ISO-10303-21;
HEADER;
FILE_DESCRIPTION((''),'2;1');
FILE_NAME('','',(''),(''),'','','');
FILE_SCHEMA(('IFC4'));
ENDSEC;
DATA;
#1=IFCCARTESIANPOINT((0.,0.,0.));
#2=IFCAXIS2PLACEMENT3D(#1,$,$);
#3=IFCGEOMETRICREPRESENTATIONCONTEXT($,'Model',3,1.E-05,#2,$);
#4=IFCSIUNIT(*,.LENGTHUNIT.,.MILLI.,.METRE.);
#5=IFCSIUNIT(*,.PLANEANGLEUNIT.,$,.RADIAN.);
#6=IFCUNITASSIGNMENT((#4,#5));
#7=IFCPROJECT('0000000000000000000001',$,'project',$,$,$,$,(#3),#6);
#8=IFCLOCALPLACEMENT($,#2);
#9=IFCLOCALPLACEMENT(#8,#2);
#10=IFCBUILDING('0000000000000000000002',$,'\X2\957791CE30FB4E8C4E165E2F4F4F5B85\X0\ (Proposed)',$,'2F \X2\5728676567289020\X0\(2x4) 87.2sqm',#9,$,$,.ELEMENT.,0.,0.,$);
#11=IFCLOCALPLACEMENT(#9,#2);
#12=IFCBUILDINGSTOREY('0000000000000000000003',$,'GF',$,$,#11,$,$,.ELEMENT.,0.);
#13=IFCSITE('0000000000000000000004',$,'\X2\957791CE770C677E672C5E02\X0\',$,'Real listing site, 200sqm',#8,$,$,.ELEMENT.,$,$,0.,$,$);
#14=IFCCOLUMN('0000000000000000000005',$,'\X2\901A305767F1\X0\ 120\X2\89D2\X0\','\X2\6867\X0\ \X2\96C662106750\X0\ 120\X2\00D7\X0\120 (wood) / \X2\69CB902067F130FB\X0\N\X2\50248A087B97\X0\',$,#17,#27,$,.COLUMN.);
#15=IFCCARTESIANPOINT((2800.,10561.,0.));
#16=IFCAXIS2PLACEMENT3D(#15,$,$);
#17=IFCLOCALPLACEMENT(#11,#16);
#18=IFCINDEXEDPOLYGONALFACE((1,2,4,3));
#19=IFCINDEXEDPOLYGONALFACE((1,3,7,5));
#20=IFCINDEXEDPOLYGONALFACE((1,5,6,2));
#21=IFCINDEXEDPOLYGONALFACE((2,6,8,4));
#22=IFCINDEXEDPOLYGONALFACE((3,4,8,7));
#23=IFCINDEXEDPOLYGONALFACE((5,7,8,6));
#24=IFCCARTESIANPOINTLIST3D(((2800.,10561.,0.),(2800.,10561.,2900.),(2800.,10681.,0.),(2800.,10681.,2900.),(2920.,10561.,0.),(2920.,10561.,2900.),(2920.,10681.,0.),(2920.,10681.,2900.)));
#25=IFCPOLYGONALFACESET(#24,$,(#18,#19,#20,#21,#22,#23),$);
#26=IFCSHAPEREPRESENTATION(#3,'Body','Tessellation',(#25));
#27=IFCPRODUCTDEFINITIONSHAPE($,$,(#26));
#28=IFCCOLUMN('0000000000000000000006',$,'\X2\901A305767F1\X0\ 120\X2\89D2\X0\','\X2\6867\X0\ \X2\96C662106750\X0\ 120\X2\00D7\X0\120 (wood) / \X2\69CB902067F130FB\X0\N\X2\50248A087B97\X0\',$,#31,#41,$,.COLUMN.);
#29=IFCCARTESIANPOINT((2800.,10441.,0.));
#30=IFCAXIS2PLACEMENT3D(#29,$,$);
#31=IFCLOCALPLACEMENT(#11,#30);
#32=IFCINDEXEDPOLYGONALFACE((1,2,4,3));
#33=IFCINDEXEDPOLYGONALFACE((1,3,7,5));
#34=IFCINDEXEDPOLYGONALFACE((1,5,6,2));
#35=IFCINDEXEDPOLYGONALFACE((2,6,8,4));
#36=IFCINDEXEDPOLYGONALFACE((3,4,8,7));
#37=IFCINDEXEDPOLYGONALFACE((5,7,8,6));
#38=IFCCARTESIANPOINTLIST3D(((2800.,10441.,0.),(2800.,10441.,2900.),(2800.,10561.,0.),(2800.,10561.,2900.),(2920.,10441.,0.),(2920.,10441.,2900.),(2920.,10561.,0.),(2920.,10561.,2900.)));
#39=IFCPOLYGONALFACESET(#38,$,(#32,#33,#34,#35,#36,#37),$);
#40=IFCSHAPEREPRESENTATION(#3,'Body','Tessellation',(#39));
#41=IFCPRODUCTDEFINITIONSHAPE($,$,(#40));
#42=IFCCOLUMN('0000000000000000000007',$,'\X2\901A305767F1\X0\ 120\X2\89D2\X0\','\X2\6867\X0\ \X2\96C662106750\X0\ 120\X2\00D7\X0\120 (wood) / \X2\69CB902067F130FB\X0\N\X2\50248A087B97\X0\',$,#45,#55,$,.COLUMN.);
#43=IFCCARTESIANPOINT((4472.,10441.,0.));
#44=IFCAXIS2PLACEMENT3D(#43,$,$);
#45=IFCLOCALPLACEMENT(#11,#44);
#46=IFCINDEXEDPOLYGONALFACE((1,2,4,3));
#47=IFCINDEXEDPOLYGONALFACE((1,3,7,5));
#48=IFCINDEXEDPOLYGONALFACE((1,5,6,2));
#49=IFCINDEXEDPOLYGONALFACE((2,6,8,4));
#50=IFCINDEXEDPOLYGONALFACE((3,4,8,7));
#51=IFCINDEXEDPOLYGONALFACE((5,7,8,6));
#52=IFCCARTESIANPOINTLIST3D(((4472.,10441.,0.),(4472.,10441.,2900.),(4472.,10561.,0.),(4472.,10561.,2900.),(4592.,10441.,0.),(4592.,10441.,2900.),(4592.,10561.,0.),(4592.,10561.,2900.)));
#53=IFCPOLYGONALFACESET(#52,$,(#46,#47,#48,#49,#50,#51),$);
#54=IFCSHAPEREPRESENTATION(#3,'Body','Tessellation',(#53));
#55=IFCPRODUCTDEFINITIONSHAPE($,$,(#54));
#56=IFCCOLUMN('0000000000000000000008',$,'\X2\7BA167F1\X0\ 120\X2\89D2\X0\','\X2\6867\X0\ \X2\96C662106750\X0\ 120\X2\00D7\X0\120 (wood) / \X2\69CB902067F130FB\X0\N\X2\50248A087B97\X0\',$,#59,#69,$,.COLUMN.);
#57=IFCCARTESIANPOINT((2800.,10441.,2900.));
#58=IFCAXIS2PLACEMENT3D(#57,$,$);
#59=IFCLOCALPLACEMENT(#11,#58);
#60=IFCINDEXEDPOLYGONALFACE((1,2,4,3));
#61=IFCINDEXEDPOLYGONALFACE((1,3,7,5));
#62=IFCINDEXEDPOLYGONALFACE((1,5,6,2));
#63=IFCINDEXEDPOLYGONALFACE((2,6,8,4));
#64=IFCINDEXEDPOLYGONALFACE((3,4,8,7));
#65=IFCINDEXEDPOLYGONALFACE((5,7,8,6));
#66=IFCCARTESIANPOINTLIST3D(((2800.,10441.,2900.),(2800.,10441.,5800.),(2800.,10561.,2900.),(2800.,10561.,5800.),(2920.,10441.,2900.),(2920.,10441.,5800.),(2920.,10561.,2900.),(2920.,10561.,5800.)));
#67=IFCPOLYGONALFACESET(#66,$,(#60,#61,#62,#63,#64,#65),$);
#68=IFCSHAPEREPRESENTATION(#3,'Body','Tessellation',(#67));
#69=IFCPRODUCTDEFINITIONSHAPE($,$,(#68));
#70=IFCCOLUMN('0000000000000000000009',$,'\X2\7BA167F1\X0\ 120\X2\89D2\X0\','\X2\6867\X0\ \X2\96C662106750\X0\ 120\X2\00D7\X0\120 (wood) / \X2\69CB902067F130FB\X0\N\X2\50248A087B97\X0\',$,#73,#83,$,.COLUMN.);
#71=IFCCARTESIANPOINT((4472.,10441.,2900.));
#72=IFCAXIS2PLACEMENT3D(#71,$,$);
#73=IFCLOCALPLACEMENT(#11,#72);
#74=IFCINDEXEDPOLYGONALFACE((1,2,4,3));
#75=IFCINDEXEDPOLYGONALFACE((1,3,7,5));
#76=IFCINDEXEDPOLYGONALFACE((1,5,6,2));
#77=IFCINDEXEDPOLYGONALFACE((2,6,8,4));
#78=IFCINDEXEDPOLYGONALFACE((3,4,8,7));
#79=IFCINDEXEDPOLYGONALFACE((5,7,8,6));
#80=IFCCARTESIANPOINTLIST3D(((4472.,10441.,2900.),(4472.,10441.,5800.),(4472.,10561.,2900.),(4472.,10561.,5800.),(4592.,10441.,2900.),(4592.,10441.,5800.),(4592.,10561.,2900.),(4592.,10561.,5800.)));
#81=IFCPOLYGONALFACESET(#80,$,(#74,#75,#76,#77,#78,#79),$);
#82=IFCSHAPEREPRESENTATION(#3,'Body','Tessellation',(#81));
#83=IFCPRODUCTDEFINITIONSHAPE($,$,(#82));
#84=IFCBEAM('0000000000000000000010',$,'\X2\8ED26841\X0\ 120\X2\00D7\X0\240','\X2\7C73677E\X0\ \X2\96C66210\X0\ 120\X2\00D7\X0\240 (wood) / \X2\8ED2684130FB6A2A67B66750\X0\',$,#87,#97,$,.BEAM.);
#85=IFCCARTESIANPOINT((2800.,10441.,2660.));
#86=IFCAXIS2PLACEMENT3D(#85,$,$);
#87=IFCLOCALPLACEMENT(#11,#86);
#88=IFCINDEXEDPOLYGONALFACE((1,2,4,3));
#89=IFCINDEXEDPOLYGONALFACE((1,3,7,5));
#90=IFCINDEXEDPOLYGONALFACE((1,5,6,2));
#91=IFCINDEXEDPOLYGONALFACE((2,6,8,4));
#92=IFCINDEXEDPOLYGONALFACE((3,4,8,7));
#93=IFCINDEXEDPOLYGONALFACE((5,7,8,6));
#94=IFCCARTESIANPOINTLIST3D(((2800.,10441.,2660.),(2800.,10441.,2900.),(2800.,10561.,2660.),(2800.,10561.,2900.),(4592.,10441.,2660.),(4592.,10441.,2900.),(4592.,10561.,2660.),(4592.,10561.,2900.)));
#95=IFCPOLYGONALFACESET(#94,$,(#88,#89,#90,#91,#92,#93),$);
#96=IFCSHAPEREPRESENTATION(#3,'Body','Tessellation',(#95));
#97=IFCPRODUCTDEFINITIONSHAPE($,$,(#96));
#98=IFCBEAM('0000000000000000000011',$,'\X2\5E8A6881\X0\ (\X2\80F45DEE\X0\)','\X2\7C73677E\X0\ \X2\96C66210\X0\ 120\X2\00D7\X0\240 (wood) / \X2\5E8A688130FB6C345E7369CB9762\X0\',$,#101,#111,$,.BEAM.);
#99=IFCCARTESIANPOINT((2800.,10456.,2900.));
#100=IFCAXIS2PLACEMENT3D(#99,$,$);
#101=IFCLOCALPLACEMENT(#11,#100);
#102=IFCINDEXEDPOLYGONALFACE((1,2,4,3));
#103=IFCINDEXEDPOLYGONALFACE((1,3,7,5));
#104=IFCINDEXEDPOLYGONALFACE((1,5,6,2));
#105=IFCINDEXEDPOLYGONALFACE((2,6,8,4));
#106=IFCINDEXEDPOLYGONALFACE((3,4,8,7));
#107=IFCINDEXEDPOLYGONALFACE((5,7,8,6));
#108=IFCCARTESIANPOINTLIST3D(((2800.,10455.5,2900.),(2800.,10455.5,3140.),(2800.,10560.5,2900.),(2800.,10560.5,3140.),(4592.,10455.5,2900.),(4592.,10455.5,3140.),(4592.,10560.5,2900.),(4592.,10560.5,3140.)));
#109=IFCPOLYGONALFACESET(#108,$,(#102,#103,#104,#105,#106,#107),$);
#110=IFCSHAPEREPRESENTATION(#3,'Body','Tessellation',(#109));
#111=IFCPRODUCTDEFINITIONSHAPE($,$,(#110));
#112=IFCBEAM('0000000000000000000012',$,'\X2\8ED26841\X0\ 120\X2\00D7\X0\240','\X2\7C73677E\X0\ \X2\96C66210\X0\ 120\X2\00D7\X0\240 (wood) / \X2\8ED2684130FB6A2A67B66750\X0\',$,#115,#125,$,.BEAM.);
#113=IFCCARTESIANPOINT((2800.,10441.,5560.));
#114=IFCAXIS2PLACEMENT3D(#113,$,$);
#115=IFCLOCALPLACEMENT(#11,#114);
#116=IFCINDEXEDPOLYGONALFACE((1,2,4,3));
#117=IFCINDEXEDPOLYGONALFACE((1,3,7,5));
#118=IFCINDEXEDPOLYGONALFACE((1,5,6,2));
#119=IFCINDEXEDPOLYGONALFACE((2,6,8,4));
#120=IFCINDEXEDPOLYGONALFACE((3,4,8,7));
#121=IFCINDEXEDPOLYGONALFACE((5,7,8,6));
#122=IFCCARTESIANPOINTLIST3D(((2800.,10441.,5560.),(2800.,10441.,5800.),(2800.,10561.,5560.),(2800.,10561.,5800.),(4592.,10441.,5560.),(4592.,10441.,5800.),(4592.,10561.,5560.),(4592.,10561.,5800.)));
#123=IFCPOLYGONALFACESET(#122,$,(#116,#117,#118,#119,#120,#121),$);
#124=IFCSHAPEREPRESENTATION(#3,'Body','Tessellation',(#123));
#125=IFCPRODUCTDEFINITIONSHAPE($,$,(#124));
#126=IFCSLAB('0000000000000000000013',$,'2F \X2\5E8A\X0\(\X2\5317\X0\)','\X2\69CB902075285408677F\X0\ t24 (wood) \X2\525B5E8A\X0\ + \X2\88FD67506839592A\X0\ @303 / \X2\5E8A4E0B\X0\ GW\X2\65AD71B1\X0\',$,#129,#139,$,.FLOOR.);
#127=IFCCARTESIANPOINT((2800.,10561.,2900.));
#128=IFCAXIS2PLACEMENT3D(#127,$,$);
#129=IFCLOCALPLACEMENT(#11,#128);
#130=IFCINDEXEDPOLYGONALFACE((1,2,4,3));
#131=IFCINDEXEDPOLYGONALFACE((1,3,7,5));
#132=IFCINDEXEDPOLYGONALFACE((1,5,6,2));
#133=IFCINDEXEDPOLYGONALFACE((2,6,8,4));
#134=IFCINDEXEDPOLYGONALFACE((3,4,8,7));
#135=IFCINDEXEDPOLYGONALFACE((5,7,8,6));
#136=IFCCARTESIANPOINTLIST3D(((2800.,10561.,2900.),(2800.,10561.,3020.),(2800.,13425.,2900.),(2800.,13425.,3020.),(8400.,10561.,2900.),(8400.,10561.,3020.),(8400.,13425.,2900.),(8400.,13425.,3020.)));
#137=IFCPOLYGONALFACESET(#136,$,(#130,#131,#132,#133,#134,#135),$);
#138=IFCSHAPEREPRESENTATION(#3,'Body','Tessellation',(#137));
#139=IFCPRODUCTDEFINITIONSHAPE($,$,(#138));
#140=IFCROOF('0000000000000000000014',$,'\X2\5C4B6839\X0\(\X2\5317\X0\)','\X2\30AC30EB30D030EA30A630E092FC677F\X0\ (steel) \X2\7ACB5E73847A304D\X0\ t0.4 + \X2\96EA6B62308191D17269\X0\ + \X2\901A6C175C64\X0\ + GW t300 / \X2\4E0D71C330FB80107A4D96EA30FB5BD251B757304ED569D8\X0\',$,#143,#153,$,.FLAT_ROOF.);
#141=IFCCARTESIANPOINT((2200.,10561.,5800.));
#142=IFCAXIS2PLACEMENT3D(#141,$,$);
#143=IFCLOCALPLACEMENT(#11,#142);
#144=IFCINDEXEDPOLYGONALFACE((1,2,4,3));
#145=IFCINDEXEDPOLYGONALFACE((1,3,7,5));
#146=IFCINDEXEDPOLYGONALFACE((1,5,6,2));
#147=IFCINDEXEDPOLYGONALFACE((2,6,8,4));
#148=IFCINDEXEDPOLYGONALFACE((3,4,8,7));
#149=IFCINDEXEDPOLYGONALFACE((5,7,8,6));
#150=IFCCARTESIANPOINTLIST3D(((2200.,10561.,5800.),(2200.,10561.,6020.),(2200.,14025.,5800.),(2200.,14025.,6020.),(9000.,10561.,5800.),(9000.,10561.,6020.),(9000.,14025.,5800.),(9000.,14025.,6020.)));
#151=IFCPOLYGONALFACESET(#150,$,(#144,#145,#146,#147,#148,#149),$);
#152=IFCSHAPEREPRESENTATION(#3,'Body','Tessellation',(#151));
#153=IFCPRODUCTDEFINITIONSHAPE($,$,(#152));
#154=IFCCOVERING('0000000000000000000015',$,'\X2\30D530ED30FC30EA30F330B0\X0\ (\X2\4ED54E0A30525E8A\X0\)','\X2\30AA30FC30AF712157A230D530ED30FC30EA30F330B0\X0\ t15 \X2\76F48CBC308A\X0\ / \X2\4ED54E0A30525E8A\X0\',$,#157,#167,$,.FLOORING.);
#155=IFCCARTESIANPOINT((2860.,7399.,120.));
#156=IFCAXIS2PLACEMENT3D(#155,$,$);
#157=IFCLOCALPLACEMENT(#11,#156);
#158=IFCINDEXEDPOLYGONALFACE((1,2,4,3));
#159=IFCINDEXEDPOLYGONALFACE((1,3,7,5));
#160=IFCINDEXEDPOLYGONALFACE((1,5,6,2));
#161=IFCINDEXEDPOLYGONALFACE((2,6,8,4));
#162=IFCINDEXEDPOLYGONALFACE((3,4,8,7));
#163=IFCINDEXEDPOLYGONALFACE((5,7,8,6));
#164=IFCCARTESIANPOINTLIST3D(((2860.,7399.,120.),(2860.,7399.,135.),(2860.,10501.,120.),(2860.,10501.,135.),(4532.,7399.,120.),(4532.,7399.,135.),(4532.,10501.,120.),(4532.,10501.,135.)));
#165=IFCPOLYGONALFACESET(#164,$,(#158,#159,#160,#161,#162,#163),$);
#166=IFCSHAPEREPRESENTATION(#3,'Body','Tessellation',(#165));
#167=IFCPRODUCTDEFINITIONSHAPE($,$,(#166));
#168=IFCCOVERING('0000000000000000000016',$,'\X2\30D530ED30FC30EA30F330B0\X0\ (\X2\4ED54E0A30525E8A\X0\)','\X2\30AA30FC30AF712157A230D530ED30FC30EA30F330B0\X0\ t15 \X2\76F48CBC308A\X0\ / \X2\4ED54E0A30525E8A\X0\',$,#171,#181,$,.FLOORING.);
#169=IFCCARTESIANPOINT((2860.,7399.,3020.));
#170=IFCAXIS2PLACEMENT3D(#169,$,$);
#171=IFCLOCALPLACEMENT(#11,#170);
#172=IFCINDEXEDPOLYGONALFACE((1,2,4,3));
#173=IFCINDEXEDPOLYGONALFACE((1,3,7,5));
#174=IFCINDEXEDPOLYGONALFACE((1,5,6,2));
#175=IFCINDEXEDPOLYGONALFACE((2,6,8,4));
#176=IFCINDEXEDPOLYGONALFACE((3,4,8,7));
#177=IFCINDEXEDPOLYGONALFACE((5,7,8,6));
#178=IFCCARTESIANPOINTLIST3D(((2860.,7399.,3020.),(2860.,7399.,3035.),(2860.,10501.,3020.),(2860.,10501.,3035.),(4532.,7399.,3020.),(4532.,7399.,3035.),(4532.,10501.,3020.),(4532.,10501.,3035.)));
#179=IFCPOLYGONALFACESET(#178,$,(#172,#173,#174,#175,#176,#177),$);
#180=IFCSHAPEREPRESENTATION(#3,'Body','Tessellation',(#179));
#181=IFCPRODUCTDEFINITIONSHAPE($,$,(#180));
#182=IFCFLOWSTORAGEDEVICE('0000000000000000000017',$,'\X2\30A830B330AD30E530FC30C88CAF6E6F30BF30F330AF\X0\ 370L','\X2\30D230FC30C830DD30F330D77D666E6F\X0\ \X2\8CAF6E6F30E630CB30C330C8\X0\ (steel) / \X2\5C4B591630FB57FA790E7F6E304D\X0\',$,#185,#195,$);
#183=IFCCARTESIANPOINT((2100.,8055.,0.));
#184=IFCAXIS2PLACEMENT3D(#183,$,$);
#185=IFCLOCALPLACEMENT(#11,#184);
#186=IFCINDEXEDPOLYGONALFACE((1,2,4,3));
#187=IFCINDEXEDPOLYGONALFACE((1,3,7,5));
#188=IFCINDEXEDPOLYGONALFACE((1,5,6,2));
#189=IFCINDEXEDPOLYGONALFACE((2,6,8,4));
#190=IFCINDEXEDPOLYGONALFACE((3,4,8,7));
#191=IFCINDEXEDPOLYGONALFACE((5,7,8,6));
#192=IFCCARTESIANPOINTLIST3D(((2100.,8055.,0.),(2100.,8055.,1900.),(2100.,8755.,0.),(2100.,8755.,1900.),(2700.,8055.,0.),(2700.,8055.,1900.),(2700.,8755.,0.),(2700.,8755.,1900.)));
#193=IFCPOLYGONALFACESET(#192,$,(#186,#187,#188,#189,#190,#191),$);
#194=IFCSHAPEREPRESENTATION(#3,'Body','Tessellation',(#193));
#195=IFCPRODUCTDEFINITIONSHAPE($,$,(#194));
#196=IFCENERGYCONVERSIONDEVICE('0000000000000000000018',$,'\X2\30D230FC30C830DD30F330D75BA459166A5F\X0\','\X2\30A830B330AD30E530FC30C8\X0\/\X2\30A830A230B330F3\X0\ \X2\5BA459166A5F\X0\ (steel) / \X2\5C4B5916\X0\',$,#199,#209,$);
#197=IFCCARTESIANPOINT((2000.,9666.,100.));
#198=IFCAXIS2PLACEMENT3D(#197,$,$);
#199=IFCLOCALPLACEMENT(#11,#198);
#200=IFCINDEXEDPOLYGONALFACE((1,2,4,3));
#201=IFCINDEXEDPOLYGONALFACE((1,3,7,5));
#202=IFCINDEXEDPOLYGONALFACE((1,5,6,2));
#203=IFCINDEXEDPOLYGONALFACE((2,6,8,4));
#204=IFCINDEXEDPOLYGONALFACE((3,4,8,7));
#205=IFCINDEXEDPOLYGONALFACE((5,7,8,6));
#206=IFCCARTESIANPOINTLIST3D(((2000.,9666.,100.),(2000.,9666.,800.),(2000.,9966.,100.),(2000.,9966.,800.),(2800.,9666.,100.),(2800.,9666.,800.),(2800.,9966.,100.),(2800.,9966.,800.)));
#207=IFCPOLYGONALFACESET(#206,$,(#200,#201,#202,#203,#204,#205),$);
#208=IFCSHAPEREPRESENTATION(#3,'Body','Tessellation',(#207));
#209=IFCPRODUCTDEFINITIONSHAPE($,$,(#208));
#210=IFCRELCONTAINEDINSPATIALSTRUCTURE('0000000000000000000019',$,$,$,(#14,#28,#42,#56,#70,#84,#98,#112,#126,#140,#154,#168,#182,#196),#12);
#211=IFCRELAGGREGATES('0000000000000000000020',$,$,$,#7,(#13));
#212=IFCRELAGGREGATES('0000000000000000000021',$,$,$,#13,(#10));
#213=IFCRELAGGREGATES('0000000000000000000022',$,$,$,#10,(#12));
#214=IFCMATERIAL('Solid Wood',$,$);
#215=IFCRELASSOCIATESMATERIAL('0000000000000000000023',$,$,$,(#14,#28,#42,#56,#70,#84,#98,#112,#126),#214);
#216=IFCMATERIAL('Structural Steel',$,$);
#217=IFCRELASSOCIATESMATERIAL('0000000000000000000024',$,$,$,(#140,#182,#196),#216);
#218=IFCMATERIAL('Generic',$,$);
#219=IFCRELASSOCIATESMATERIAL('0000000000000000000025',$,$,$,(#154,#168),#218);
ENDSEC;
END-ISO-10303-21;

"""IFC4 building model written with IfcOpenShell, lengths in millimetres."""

from ifc_helpers import new_model, si_unit, frame, frame_2d, origin, place, context, project, spatial, rectangle, extrude, material, element, save


model = new_model("IFC4")

# Units and contexts
model_context = context("Model", 3, precision=1e-05, world=origin())
ifc_project = project(units=[si_unit("LENGTHUNIT", "METRE", prefix="MILLI"), si_unit("PLANEANGLEUNIT", "RADIAN")], contexts=[model_context])

# Site, building, storey
site_placement = place(None, origin())
site = spatial("IfcSite", under=ifc_project, at=site_placement, Name="長野県松本市", ObjectType="Real listing site, 200sqm", CompositionType="ELEMENT", RefElevation=0.0)
building_placement = place(site_placement, origin())
building = spatial("IfcBuilding", under=site, at=building_placement, Name="長野・二世帯住宅 (Proposed)", ObjectType="2F 在来木造(2x4) 87.2sqm", CompositionType="ELEMENT", ElevationOfRefHeight=0.0, ElevationOfTerrain=0.0)
storey_placement = place(building_placement, origin())
storey = spatial("IfcBuildingStorey", under=building, at=storey_placement, Name="GF", CompositionType="ELEMENT", Elevation=0.0)

# Columns
ifc_material_1 = material(Name="Solid Wood")
column_1_placement = place(storey_placement, frame((2800.0, 10561.0, 0.0)))
element("IfcColumn", 1, at=column_1_placement, inside=storey, material=ifc_material_1, Name="通し柱 120角", Description="桧 集成材 120×120 (wood) / 構造柱・N値計算", PredefinedType="COLUMN", context=model_context, shape_type="SweptSolid", body=[
    extrude(rectangle(XDim=120.0, YDim=120.0, at=frame_2d((60.0, 60.0))), frame((2800.0, 10561.0, 0.0)), (0.0, 0.0, 1.0), 2900.0),
])
column_2_placement = place(storey_placement, frame((2800.0, 10441.0, 0.0)))
element("IfcColumn", 2, at=column_2_placement, inside=storey, material=ifc_material_1, Name="通し柱 120角", Description="桧 集成材 120×120 (wood) / 構造柱・N値計算", PredefinedType="COLUMN", context=model_context, shape_type="SweptSolid", body=[
    extrude(rectangle(XDim=120.0, YDim=120.0, at=frame_2d((60.0, 60.0))), frame((2800.0, 10441.0, 0.0)), (0.0, 0.0, 1.0), 2900.0),
])
column_3_placement = place(storey_placement, frame((4472.0, 10441.0, 0.0)))
element("IfcColumn", 3, at=column_3_placement, inside=storey, material=ifc_material_1, Name="通し柱 120角", Description="桧 集成材 120×120 (wood) / 構造柱・N値計算", PredefinedType="COLUMN", context=model_context, shape_type="SweptSolid", body=[
    extrude(rectangle(XDim=120.0, YDim=120.0, at=frame_2d((60.0, 60.0))), frame((4472.0, 10441.0, 0.0)), (0.0, 0.0, 1.0), 2900.0),
])
column_4_placement = place(storey_placement, frame((2800.0, 10441.0, 2900.0)))
element("IfcColumn", 4, at=column_4_placement, inside=storey, material=ifc_material_1, Name="管柱 120角", Description="桧 集成材 120×120 (wood) / 構造柱・N値計算", PredefinedType="COLUMN", context=model_context, shape_type="SweptSolid", body=[
    extrude(rectangle(XDim=120.0, YDim=120.0, at=frame_2d((60.0, 60.0))), frame((2800.0, 10441.0, 2900.0)), (0.0, 0.0, 1.0), 2900.0),
])
column_5_placement = place(storey_placement, frame((4472.0, 10441.0, 2900.0)))
element("IfcColumn", 5, at=column_5_placement, inside=storey, material=ifc_material_1, Name="管柱 120角", Description="桧 集成材 120×120 (wood) / 構造柱・N値計算", PredefinedType="COLUMN", context=model_context, shape_type="SweptSolid", body=[
    extrude(rectangle(XDim=120.0, YDim=120.0, at=frame_2d((60.0, 60.0))), frame((4472.0, 10441.0, 2900.0)), (0.0, 0.0, 1.0), 2900.0),
])

# Beams
beam_1_placement = place(storey_placement, frame((2800.0, 10441.0, 2660.0)))
element("IfcBeam", 6, at=beam_1_placement, inside=storey, material=ifc_material_1, Name="軒桁 120×240", Description="米松 集成 120×240 (wood) / 軒桁・横架材", PredefinedType="BEAM", context=model_context, shape_type="SweptSolid", body=[
    extrude(rectangle(XDim=1792.0, YDim=120.0, at=frame_2d((896.0, 60.0))), frame((2800.0, 10441.0, 2660.0)), (0.0, 0.0, 1.0), 240.0),
])
beam_2_placement = place(storey_placement, frame((2800.0, 10456.0, 2900.0)))
element("IfcBeam", 7, at=beam_2_placement, inside=storey, material=ifc_material_1, Name="床梁 (胴差)", Description="米松 集成 120×240 (wood) / 床梁・水平構面", PredefinedType="BEAM", context=model_context, shape_type="SweptSolid", body=[
    extrude(rectangle(XDim=1792.0, YDim=105.0, at=frame_2d((896.0, 52.0))), frame((2800.0, 10456.0, 2900.0)), (0.0, 0.0, 1.0), 240.0),
])
beam_3_placement = place(storey_placement, frame((2800.0, 10441.0, 5560.0)))
element("IfcBeam", 8, at=beam_3_placement, inside=storey, material=ifc_material_1, Name="軒桁 120×240", Description="米松 集成 120×240 (wood) / 軒桁・横架材", PredefinedType="BEAM", context=model_context, shape_type="SweptSolid", body=[
    extrude(rectangle(XDim=1792.0, YDim=120.0, at=frame_2d((896.0, 60.0))), frame((2800.0, 10441.0, 5560.0)), (0.0, 0.0, 1.0), 240.0),
])

# Slab
slab_1_placement = place(storey_placement, frame((2800.0, 10561.0, 2900.0)))
element("IfcSlab", 9, at=slab_1_placement, inside=storey, material=ifc_material_1, Name="2F 床(北)", Description="構造用合板 t24 (wood) 剛床 + 製材根太 @303 / 床下 GW断熱", PredefinedType="FLOOR", context=model_context, shape_type="SweptSolid", body=[
    extrude(rectangle(XDim=5600.0, YDim=2864.0, at=frame_2d((2800.0, 1432.0))), frame((2800.0, 10561.0, 2900.0)), (0.0, 0.0, 1.0), 120.0),
])

# Roof
ifc_material_2 = material(Name="Structural Steel")
for number, where, name in (
    (10, (2200.0, 10561.0, 5800.0), "屋根(北)"),
):
    element("IfcRoof", number, at=place(storey_placement, frame(where)), inside=storey, material=ifc_material_2, Name=name, Description="ガルバリウム鋼板 (steel) 立平葺き t0.4 + 雪止め金物 + 通気層 + GW t300 / 不燃・耐積雪・寒冷地仕様", PredefinedType="FLAT_ROOF", context=model_context, shape_type="SweptSolid", body=[
        extrude(rectangle(XDim=6800.0, YDim=3464.0, at=frame_2d((3400.0, 1732.0))), frame((2200.0, 10561.0, 5800.0)), (0.0, 0.0, 1.0), 220.0),
    ])

# Coverings
ifc_material_3 = material(Name="Generic")
covering_1_placement = place(storey_placement, frame((2860.0, 7399.0, 120.0)))
element("IfcCovering", 11, at=covering_1_placement, inside=storey, material=ifc_material_3, Name="フローリング (仕上げ床)", Description="オーク無垢フローリング t15 直貼り / 仕上げ床", PredefinedType="FLOORING", context=model_context, shape_type="SweptSolid", body=[
    extrude(rectangle(XDim=1672.0, YDim=3102.0, at=frame_2d((836.0, 1551.0))), frame((2860.0, 7399.0, 120.0)), (0.0, 0.0, 1.0), 15.0),
])
covering_2_placement = place(storey_placement, frame((2860.0, 7399.0, 3020.0)))
element("IfcCovering", 12, at=covering_2_placement, inside=storey, material=ifc_material_3, Name="フローリング (仕上げ床)", Description="オーク無垢フローリング t15 直貼り / 仕上げ床", PredefinedType="FLOORING", context=model_context, shape_type="SweptSolid", body=[
    extrude(rectangle(XDim=1672.0, YDim=3102.0, at=frame_2d((836.0, 1551.0))), frame((2860.0, 7399.0, 3020.0)), (0.0, 0.0, 1.0), 15.0),
])

# Flow storage device
flow_storage_device_placement = place(storey_placement, frame((2100.0, 8055.0, 0.0)))
element("IfcFlowStorageDevice", 13, at=flow_storage_device_placement, inside=storey, material=ifc_material_2, Name="エコキュート貯湯タンク 370L", Description="ヒートポンプ給湯 貯湯ユニット (steel) / 屋外・基礎置き", context=model_context, shape_type="SweptSolid", body=[
    extrude(rectangle(XDim=600.0, YDim=700.0, at=frame_2d((300.0, 350.0))), frame((2100.0, 8055.0, 0.0)), (0.0, 0.0, 1.0), 1900.0),
])

# Energy conversion device
energy_conversion_device_placement = place(storey_placement, frame((2000.0, 9666.0, 100.0)))
element("IfcEnergyConversionDevice", 14, at=energy_conversion_device_placement, inside=storey, material=ifc_material_2, Name="ヒートポンプ室外機", Description="エコキュート/エアコン 室外機 (steel) / 屋外", context=model_context, shape_type="SweptSolid", body=[
    extrude(rectangle(XDim=800.0, YDim=300.0, at=frame_2d((400.0, 150.0))), frame((2000.0, 9666.0, 100.0)), (0.0, 0.0, 1.0), 700.0),
])

save(model, "model.ifc")
